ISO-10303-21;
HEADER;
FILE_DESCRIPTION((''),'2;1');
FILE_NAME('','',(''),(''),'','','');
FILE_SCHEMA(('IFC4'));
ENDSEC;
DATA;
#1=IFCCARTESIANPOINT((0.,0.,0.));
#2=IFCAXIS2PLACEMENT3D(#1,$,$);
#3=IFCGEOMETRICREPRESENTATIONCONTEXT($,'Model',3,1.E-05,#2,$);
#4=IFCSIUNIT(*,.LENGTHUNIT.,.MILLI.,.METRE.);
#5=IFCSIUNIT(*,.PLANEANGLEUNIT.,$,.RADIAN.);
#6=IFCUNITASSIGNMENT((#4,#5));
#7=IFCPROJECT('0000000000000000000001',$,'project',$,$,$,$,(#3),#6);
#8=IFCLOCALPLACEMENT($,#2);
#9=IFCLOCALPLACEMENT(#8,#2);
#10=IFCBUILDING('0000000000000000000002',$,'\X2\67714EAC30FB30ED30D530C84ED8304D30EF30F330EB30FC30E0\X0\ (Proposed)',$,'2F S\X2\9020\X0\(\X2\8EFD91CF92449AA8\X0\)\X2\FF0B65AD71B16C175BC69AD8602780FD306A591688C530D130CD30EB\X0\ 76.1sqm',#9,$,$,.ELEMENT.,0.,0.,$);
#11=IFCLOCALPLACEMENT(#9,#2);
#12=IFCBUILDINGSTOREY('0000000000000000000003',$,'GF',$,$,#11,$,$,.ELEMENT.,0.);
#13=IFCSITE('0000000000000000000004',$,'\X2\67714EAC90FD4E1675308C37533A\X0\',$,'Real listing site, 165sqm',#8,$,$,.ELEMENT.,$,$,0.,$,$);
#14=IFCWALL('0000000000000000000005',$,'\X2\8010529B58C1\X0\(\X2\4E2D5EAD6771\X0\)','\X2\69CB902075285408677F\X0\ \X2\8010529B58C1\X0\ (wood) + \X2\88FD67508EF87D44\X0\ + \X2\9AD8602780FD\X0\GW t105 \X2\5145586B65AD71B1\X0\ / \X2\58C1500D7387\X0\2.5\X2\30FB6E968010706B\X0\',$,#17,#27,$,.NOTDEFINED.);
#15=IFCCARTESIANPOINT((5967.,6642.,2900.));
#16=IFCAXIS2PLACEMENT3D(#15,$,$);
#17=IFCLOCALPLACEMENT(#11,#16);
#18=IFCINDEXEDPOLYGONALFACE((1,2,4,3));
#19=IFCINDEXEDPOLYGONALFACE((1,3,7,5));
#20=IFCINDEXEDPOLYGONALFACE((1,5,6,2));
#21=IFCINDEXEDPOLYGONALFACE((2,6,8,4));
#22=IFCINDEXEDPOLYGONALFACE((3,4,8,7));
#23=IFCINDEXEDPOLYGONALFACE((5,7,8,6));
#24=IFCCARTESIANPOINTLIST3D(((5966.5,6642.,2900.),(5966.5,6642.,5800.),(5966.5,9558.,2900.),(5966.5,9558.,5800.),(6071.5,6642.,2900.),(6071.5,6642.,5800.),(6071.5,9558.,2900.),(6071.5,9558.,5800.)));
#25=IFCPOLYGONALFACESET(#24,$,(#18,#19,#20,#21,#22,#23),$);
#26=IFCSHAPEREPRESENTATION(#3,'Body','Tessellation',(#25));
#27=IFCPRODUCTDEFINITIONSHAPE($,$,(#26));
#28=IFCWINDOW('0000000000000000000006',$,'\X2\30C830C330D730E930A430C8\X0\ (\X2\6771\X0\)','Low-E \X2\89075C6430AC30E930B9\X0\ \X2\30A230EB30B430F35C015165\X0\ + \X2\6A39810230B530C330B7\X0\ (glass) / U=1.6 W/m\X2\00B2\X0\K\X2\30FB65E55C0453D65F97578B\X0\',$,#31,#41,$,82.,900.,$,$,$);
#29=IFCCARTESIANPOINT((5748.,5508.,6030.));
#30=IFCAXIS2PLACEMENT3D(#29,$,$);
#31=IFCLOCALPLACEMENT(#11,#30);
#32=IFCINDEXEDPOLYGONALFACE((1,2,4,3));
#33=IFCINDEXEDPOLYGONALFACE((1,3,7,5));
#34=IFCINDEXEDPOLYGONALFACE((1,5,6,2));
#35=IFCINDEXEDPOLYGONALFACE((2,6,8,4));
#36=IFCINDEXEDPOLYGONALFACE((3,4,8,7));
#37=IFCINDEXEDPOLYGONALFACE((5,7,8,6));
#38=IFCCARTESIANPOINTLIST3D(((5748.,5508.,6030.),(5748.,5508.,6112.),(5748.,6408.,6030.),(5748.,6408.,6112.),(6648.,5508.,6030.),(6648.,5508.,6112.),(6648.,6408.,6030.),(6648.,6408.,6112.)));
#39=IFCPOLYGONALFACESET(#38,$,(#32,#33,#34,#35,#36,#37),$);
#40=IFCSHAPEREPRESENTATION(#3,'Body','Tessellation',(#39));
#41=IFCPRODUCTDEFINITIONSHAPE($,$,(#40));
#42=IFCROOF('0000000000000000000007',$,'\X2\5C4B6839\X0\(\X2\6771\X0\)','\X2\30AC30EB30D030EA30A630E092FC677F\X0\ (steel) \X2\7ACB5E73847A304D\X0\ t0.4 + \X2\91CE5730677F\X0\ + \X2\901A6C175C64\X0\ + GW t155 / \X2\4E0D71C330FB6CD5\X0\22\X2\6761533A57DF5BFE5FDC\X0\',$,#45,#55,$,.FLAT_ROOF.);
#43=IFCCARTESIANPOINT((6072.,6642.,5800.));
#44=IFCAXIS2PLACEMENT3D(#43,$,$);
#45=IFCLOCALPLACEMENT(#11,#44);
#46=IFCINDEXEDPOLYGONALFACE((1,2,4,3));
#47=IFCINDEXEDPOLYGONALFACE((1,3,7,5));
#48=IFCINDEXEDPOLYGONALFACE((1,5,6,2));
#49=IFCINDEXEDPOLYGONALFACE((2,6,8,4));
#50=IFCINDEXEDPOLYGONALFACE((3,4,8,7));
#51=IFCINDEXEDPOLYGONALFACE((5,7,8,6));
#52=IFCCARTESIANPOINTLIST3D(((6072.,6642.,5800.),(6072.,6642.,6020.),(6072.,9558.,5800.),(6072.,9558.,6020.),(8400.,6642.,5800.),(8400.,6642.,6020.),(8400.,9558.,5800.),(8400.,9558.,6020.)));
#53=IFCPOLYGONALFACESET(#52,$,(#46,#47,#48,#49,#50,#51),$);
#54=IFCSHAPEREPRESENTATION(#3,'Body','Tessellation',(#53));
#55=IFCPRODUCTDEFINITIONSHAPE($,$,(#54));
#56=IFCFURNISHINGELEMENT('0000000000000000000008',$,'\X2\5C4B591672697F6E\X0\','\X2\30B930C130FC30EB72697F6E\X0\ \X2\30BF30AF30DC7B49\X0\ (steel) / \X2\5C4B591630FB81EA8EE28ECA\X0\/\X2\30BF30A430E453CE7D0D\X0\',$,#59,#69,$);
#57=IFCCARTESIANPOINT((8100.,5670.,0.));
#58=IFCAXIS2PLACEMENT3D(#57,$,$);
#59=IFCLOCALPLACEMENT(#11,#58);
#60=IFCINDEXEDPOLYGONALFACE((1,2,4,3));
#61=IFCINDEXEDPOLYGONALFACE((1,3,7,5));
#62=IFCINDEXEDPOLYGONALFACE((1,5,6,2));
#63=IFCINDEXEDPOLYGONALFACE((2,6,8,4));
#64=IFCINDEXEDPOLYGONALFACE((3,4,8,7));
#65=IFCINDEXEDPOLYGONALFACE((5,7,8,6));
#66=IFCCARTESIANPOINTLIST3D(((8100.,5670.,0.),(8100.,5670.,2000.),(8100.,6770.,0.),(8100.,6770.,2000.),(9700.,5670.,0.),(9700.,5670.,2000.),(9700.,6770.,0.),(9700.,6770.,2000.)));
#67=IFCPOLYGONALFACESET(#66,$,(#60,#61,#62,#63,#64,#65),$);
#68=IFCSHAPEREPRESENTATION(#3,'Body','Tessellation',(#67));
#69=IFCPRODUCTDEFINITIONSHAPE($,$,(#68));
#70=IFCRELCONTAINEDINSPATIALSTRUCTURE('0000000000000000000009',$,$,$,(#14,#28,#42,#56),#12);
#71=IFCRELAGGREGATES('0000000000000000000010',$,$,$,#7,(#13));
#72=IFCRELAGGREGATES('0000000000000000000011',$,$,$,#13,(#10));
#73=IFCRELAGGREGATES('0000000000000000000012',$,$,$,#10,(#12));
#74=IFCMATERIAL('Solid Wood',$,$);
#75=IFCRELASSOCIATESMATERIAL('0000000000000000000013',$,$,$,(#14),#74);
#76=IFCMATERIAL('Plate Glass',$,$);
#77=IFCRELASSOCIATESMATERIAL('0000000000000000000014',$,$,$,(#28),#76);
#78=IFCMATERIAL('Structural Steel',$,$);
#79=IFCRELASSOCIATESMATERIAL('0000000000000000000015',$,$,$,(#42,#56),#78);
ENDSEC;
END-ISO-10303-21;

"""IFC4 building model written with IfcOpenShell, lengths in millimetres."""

from ifc_helpers import new_model, si_unit, frame, frame_2d, origin, place, context, project, spatial, rectangle, extrude, material, element, save


model = new_model("IFC4")

# Units and contexts
model_context = context("Model", 3, precision=1e-05, world=origin())
ifc_project = project(units=[si_unit("LENGTHUNIT", "METRE", prefix="MILLI"), si_unit("PLANEANGLEUNIT", "RADIAN")], contexts=[model_context])

# Site, building, storey
site_placement = place(None, origin())
site = spatial("IfcSite", under=ifc_project, at=site_placement, Name="東京都世田谷区", ObjectType="Real listing site, 165sqm", CompositionType="ELEMENT", RefElevation=0.0)
building_placement = place(site_placement, origin())
building = spatial("IfcBuilding", under=site, at=building_placement, Name="東京・ロフト付きワンルーム (Proposed)", ObjectType="2F S造(軽量鉄骨)＋断熱気密高性能な外装パネル 76.1sqm", CompositionType="ELEMENT", ElevationOfRefHeight=0.0, ElevationOfTerrain=0.0)
storey_placement = place(building_placement, origin())
storey = spatial("IfcBuildingStorey", under=building, at=storey_placement, Name="GF", CompositionType="ELEMENT", Elevation=0.0)

# Shared definitions
ifc_material_1 = material(Name="Solid Wood")

# Shared definitions
ifc_material_2 = material(Name="Plate Glass")

# Wall
wall_1_placement = place(storey_placement, frame((5967.0, 6642.0, 2900.0)))
element("IfcWall", 1, at=wall_1_placement, inside=storey, material=ifc_material_1, Name="耐力壁(中庭東)", Description="構造用合板 耐力壁 (wood) + 製材軸組 + 高性能GW t105 充填断熱 / 壁倍率2.5・準耐火", PredefinedType="NOTDEFINED", context=model_context, shape_type="SweptSolid", body=[
    extrude(rectangle(XDim=105.0, YDim=2916.0, at=frame_2d((52.0, 1458.0))), frame((5967.0, 6642.0, 2900.0)), (0.0, 0.0, 1.0), 2900.0),
])

# Window
window_1_placement = place(storey_placement, frame((5748.0, 5508.0, 6030.0)))
element("IfcWindow", 2, at=window_1_placement, inside=storey, material=ifc_material_2, Name="トップライト (東)", Description="Low-E 複層ガラス アルゴン封入 + 樹脂サッシ (glass) / U=1.6 W/m²K・日射取得型", OverallHeight=82.0, OverallWidth=900.0, context=model_context, shape_type="SweptSolid", body=[
    extrude(rectangle(XDim=900.0, YDim=900.0, at=frame_2d((450.0, 450.0))), frame((5748.0, 5508.0, 6030.0)), (0.0, 0.0, 1.0), 82.0),
])

# Roof
ifc_material_3 = material(Name="Structural Steel")
for number, where, name in (
    (3, (6072.0, 6642.0, 5800.0), "屋根(東)"),
):
    element("IfcRoof", number, at=place(storey_placement, frame(where)), inside=storey, material=ifc_material_3, Name=name, Description="ガルバリウム鋼板 (steel) 立平葺き t0.4 + 野地板 + 通気層 + GW t155 / 不燃・法22条区域対応", PredefinedType="FLAT_ROOF", context=model_context, shape_type="SweptSolid", body=[
        extrude(rectangle(XDim=2328.0, YDim=2916.0, at=frame_2d((1164.0, 1458.0))), frame((6072.0, 6642.0, 5800.0)), (0.0, 0.0, 1.0), 220.0),
    ])

# Furnishing element
furnishing_placement = place(storey_placement, frame((8100.0, 5670.0, 0.0)))
element("IfcFurnishingElement", 4, at=furnishing_placement, inside=storey, material=ifc_material_3, Name="屋外物置", Description="スチール物置 タクボ等 (steel) / 屋外・自転車/タイヤ収納", context=model_context, shape_type="SweptSolid", body=[
    extrude(rectangle(XDim=1600.0, YDim=1100.0, at=frame_2d((800.0, 550.0))), frame((8100.0, 5670.0, 0.0)), (0.0, 0.0, 1.0), 2000.0),
])

save(model, "model.ifc")
